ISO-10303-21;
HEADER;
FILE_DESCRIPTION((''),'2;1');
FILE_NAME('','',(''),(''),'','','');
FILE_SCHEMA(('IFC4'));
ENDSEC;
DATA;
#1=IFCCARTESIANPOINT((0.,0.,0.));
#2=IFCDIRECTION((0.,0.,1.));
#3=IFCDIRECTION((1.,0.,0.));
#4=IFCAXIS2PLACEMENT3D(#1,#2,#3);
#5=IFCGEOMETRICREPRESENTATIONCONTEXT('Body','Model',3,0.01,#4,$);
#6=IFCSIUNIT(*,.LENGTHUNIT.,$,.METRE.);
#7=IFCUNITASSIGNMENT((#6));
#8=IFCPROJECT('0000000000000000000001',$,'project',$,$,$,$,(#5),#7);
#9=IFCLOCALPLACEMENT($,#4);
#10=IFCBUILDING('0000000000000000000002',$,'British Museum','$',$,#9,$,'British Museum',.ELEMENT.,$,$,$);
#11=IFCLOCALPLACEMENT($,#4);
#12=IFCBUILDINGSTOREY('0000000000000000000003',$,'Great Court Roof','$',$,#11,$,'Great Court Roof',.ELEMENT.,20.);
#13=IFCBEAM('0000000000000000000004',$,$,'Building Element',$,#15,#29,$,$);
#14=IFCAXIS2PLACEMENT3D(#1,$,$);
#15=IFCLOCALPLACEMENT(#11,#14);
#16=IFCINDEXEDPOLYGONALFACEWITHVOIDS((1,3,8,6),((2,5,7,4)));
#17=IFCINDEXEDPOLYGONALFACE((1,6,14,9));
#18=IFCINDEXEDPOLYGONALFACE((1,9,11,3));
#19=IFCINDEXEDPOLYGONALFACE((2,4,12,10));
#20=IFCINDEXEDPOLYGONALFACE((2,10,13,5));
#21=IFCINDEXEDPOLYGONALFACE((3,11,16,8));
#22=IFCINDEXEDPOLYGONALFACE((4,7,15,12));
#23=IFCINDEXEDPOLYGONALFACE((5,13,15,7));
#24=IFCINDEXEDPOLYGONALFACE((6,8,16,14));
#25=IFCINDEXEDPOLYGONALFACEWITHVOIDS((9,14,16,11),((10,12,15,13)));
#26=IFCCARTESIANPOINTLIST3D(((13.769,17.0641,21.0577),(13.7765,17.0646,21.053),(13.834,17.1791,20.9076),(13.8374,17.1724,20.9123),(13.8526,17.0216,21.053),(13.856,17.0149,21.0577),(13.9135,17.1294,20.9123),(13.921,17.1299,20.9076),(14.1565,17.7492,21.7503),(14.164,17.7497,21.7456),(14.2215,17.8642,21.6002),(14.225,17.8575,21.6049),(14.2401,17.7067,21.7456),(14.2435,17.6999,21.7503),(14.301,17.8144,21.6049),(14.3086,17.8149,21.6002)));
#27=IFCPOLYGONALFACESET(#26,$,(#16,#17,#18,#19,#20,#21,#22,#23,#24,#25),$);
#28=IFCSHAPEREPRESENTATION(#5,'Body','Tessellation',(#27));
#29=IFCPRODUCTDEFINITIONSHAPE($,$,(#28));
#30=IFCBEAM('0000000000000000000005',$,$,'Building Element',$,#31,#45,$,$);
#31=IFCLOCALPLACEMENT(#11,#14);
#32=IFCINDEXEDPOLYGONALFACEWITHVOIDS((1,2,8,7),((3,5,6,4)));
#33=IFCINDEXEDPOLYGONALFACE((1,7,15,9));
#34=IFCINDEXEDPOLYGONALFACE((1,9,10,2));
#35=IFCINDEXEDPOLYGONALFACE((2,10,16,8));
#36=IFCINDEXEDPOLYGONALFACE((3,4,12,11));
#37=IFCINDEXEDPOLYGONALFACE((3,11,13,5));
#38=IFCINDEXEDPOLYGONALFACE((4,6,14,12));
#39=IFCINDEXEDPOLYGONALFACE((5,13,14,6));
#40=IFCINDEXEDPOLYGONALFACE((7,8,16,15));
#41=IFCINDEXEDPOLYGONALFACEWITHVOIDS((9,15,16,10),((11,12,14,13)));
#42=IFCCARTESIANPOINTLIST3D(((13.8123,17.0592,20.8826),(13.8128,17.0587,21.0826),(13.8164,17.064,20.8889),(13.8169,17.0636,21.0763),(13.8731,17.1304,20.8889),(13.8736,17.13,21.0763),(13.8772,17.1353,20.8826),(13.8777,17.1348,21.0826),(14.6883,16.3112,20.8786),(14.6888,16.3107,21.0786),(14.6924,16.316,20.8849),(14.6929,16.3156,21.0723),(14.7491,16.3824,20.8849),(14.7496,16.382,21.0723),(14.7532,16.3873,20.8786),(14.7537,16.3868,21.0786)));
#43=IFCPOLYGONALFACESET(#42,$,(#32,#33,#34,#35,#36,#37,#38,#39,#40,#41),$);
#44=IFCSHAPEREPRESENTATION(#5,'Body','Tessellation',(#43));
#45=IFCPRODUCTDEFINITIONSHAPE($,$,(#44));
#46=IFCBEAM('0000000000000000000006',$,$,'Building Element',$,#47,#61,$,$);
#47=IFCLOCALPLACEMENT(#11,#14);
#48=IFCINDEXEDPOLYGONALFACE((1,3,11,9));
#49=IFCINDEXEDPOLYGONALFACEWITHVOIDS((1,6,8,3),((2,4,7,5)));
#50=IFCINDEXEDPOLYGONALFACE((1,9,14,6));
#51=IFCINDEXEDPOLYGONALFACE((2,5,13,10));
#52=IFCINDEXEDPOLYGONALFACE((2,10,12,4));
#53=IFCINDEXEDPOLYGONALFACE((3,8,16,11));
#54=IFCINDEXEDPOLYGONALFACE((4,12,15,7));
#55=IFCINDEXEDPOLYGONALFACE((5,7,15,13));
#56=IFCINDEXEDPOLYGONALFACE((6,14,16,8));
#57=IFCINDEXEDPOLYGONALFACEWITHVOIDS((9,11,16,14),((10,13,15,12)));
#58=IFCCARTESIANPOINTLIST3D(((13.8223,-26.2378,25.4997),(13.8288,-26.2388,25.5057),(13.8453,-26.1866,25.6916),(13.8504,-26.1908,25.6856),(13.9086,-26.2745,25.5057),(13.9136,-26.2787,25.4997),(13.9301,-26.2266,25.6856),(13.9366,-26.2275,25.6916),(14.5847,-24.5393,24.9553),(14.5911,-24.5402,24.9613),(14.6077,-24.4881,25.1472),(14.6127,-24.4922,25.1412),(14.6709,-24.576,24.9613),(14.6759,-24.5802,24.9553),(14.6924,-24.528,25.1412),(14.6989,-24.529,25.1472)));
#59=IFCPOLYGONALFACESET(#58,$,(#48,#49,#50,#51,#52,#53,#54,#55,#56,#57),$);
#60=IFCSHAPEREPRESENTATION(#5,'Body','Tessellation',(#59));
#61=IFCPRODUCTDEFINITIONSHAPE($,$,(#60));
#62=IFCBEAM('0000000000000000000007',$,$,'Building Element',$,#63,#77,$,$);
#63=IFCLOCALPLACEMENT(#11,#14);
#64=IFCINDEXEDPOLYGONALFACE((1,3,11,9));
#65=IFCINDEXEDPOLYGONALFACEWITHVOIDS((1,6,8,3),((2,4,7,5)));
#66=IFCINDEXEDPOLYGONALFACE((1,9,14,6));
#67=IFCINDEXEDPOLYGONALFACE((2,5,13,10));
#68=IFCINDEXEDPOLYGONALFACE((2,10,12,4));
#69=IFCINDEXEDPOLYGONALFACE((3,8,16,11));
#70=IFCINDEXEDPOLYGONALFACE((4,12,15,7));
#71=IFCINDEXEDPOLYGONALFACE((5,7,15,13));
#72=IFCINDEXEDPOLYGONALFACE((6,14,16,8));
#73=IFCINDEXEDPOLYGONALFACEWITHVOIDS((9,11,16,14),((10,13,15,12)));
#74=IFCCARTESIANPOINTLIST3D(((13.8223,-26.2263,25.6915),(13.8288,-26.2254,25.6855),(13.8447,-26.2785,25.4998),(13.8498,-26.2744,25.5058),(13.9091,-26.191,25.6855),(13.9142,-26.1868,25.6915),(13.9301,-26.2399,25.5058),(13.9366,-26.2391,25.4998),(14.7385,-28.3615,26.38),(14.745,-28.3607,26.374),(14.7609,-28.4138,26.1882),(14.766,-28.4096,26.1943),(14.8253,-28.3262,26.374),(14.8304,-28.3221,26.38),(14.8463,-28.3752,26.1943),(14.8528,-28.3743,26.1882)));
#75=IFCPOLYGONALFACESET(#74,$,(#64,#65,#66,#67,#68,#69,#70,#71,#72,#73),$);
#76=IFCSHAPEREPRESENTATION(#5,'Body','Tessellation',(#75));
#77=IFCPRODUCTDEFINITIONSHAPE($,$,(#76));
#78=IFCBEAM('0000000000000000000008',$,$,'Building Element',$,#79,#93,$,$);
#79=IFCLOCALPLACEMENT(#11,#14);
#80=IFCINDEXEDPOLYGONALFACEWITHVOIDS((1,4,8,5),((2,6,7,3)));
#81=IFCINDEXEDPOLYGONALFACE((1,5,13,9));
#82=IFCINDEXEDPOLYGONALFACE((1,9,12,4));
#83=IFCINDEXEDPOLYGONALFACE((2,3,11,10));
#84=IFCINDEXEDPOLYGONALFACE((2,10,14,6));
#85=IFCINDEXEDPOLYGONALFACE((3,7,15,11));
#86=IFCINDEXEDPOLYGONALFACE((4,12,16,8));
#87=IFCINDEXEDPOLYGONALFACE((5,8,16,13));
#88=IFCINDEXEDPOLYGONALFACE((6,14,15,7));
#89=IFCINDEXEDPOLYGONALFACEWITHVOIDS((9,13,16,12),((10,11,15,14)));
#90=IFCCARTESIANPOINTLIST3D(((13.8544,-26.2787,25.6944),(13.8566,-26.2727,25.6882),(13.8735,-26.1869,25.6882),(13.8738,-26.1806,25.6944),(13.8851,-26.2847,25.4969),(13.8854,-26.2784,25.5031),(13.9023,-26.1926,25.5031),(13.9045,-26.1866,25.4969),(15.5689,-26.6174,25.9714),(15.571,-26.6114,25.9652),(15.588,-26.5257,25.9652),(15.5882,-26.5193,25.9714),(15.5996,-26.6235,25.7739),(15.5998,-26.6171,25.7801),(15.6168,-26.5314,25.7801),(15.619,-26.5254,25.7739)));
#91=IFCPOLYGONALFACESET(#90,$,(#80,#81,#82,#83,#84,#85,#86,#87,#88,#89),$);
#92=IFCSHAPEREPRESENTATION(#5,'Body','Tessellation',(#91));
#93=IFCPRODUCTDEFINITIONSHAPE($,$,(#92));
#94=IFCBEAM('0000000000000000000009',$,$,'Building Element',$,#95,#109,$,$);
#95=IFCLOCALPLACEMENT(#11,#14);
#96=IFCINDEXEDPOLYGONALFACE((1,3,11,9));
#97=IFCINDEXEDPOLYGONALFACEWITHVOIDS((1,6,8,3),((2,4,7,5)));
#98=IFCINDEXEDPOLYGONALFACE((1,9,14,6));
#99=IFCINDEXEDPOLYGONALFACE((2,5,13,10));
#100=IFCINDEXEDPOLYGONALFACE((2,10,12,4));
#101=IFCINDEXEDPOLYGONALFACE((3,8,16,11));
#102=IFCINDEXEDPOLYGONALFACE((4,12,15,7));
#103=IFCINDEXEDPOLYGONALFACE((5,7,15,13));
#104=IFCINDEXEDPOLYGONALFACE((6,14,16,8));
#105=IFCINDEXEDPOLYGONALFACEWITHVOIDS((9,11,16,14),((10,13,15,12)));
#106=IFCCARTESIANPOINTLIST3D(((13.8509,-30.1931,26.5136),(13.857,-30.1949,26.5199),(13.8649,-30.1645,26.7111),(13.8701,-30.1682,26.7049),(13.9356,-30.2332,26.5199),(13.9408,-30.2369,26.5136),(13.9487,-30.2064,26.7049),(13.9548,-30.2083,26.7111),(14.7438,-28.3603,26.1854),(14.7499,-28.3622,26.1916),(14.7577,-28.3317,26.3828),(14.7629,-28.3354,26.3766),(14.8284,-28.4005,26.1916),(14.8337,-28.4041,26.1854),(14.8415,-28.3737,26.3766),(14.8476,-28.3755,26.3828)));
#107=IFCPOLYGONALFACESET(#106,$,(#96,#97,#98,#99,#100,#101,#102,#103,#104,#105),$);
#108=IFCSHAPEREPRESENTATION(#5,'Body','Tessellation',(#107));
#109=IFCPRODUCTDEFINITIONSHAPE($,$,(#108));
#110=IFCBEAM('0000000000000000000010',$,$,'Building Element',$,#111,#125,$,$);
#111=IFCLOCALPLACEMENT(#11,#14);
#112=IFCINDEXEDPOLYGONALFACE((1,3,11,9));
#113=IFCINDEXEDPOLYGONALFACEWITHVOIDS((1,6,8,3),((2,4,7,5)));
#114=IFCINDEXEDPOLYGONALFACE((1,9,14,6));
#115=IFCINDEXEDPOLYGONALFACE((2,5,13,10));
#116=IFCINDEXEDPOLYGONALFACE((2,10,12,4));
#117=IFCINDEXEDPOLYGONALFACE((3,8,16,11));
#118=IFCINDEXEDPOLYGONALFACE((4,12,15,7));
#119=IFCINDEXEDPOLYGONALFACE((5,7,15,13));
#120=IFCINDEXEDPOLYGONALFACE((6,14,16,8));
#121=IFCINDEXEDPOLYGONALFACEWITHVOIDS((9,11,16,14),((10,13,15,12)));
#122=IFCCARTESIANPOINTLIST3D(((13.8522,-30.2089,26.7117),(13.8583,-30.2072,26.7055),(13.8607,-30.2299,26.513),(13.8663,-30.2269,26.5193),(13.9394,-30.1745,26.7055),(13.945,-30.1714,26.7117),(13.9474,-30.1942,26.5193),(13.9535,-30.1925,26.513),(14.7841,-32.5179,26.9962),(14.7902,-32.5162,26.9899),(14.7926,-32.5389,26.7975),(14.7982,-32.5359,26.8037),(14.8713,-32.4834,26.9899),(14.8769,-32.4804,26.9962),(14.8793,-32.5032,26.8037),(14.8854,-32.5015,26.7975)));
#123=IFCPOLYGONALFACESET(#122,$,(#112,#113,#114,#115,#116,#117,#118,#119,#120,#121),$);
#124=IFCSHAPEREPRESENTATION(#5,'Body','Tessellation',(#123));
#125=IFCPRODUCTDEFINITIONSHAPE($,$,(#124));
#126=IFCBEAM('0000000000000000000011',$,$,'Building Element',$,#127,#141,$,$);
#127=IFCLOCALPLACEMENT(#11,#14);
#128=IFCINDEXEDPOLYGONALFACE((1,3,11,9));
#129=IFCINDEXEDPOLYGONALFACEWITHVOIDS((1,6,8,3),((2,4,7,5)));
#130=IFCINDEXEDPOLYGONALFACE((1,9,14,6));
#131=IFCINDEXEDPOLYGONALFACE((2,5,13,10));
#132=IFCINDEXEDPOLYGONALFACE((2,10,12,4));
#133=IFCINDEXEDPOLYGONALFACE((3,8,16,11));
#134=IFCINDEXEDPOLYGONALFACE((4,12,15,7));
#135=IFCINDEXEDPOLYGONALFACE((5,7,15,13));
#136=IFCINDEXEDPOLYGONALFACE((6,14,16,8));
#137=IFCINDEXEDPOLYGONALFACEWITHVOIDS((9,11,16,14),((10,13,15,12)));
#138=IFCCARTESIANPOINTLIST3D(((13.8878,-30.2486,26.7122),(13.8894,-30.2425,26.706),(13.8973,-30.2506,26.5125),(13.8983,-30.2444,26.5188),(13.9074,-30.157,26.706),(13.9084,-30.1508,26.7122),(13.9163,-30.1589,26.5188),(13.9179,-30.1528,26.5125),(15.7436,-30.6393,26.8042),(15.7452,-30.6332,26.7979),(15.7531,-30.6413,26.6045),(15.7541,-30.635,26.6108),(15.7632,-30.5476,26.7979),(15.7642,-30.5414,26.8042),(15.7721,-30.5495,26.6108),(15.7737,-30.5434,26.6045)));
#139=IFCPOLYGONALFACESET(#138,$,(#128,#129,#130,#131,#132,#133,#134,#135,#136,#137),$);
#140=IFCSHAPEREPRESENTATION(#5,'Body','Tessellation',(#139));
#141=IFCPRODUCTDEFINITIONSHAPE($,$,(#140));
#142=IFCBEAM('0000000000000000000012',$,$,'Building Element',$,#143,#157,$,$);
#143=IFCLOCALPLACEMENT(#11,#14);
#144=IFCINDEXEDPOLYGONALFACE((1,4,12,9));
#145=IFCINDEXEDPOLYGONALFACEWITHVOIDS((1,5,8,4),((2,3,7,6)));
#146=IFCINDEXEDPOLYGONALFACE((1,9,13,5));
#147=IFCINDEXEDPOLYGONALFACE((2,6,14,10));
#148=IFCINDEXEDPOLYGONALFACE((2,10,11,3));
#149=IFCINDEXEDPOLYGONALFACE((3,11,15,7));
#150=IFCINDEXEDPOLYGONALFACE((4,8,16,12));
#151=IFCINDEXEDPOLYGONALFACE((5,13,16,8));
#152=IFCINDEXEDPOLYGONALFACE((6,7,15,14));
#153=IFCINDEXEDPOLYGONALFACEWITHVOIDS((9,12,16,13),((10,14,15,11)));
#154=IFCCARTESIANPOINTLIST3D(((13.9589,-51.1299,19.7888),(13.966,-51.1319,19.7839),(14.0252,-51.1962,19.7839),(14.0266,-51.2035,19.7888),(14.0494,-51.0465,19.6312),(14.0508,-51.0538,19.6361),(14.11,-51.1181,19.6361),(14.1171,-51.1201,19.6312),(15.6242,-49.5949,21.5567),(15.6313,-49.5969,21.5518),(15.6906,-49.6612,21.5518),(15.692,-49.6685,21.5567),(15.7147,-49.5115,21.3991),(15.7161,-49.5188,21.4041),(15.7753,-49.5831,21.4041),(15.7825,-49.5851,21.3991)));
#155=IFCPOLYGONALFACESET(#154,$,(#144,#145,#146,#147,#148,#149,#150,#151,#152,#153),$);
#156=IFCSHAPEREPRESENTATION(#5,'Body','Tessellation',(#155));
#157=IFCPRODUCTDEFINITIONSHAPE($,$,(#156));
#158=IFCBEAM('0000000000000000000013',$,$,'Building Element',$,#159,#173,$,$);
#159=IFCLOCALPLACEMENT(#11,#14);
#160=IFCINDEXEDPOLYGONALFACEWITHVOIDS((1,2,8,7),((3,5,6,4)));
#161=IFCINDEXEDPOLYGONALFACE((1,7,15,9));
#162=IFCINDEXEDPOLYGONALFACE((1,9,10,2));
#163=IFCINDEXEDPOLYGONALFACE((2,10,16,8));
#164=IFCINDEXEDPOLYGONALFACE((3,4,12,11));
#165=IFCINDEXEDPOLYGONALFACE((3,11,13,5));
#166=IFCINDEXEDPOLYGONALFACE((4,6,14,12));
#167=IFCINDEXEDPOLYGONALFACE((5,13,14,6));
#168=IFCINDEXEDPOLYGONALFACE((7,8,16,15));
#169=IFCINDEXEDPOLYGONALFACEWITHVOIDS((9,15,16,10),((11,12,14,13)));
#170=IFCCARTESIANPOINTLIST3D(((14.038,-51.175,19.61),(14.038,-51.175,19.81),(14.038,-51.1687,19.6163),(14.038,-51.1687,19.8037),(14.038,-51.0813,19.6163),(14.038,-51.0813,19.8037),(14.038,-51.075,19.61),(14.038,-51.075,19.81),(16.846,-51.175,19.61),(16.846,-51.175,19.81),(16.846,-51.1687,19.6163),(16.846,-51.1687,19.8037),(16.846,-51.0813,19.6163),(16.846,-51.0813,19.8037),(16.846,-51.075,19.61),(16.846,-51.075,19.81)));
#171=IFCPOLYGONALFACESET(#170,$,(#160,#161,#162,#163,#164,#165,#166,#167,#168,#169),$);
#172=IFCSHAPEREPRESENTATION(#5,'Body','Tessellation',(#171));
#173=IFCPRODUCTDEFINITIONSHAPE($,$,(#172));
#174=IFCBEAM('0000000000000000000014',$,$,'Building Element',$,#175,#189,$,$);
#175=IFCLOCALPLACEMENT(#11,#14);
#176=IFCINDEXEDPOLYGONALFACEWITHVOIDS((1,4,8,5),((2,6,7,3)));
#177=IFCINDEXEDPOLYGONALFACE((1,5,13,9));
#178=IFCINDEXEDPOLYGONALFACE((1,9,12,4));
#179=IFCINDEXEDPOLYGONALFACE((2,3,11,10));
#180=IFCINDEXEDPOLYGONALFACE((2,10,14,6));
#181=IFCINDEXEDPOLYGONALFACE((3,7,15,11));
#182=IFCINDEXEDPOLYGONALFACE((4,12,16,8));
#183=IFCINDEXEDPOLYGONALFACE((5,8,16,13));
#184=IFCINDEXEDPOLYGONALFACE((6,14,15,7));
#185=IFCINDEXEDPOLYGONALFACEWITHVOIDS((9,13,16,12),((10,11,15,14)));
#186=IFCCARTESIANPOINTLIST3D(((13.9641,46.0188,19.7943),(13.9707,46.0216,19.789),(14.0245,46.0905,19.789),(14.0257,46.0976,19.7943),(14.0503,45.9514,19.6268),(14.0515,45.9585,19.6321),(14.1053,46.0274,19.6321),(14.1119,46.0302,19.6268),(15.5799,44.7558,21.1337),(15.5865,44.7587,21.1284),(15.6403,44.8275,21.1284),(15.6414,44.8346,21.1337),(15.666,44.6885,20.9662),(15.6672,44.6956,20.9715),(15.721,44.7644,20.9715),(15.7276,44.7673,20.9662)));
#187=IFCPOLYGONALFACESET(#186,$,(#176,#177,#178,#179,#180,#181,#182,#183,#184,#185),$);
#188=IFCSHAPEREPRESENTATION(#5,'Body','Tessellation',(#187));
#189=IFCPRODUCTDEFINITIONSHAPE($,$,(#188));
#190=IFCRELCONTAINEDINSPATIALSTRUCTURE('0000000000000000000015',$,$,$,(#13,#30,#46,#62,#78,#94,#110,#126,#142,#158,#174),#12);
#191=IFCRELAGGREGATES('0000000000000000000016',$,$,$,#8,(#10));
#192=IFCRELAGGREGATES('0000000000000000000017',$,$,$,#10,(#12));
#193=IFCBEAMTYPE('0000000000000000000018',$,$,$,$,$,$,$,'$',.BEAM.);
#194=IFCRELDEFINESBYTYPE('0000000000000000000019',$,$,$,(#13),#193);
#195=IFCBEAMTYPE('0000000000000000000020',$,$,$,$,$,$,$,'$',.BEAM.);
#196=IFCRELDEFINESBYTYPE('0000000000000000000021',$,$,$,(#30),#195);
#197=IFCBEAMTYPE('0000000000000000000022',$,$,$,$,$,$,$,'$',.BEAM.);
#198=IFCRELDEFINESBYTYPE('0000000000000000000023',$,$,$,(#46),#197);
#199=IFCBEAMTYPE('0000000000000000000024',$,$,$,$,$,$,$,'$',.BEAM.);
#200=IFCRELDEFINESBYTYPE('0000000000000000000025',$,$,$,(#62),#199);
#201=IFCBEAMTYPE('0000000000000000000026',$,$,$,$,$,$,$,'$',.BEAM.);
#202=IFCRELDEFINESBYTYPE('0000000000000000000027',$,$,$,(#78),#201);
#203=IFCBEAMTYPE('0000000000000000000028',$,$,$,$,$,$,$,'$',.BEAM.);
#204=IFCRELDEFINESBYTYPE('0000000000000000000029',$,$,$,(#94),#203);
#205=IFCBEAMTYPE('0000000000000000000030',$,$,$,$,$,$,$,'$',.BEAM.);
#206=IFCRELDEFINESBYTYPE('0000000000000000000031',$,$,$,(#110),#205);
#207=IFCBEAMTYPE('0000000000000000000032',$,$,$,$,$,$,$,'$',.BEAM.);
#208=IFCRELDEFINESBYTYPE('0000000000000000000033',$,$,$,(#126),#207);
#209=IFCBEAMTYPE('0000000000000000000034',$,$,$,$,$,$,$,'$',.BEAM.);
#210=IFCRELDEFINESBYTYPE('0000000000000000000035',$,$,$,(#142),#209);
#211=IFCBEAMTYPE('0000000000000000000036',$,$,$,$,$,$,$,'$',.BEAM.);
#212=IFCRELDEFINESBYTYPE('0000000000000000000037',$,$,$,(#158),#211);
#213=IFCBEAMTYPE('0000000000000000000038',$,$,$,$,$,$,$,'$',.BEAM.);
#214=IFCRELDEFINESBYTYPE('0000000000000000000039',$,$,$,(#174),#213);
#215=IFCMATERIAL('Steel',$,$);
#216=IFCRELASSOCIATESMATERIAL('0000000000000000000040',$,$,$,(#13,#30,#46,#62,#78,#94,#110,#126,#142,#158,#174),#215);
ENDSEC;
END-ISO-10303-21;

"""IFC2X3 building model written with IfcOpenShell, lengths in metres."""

from ifc_helpers import new_model, si_unit, frame, origin_with_axes, origin_2d, place, context, project, spatial, hollow_rectangle, extrude, material, type_object, element, save


model = new_model("IFC2X3")

# Units and contexts
model_context = context("Model", 3, precision=0.01, world=origin_with_axes(), identifier="Body")
ifc_project = project(units=[si_unit("LENGTHUNIT", "METRE")], contexts=[model_context])

# Building, storey
building_placement = place(None, origin_with_axes())
building = spatial("IfcBuilding", under=ifc_project, at=building_placement, Name="British Museum", Description="$", LongName="British Museum", CompositionType="ELEMENT")
storey_placement = place(None, origin_with_axes())
storey = spatial("IfcBuildingStorey", under=building, at=storey_placement, Name="Great Court Roof", Description="$", LongName="Great Court Roof", CompositionType="ELEMENT", Elevation=20.0)

# Beams
ifc_material = material(Name="Steel")
beam_type_1 = type_object("IfcBeamType", ElementType="$", PredefinedType="BEAM")
beam_1_placement = place(None, origin_with_axes())
element("IfcBeam", 1, at=beam_1_placement, inside=storey, type_object=beam_type_1, material=ifc_material, Description="Building Element", context=model_context, shape_type="SweptSolid", body=[
    extrude(hollow_rectangle(XDim=0.1, YDim=0.2, WallThickness=0.0063, InnerFilletRadius=-0.0063, OuterFilletRadius=0.0, at=origin_2d()), frame((13.845, 17.097, 20.9826), z_axis=(0.369627, 0.653425, 0.660614), x_axis=(-0.870392, 0.49236, 0.0)), (0.0, 0.0, 1.0), 1.0484),
])
beam_type_2 = type_object("IfcBeamType", ElementType="$", PredefinedType="BEAM")
beam_2_placement = place(None, origin_with_axes())
element("IfcBeam", 2, at=beam_2_placement, inside=storey, type_object=beam_type_2, material=ifc_material, Description="Building Element", context=model_context, shape_type="SweptSolid", body=[
    extrude(hollow_rectangle(XDim=0.1, YDim=0.2, WallThickness=0.0063, InnerFilletRadius=-0.0063, OuterFilletRadius=0.0, at=origin_2d()), frame((13.845, 17.097, 20.9826), z_axis=(0.760477, -0.649356, -0.003504), x_axis=(0.64936, 0.760481, 0.0)), (0.0, 0.0, 1.0), 1.1519),
])
beam_type_3 = type_object("IfcBeamType", ElementType="$", PredefinedType="BEAM")
beam_3_placement = place(None, origin_with_axes())
element("IfcBeam", 3, at=beam_3_placement, inside=storey, type_object=beam_type_3, material=ifc_material, Description="Building Element", context=model_context, shape_type="SweptSolid", body=[
    extrude(hollow_rectangle(XDim=0.1, YDim=0.2, WallThickness=0.0063, InnerFilletRadius=-0.0063, OuterFilletRadius=0.0, at=origin_2d()), frame((13.8795, -26.2327, 25.5957), z_axis=(0.393009, 0.875656, -0.28066), x_axis=(-0.912325, 0.409466, 0.0)), (0.0, 0.0, 1.0), 1.9397),
])
beam_type_4 = type_object("IfcBeamType", ElementType="$", PredefinedType="BEAM")
beam_4_placement = place(None, origin_with_axes())
element("IfcBeam", 4, at=beam_4_placement, inside=storey, type_object=beam_type_4, material=ifc_material, Description="Building Element", context=model_context, shape_type="SweptSolid", body=[
    extrude(hollow_rectangle(XDim=0.1, YDim=0.2, WallThickness=0.0063, InnerFilletRadius=-0.0063, OuterFilletRadius=0.0, at=origin_2d()), frame((13.8795, -26.2327, 25.5957), z_axis=(0.378075, -0.88111, 0.284086), x_axis=(0.918973, 0.394321, 0.0)), (0.0, 0.0, 1.0), 2.4234),
])
beam_type_5 = type_object("IfcBeamType", ElementType="$", PredefinedType="BEAM")
beam_5_placement = place(None, origin_with_axes())
element("IfcBeam", 5, at=beam_5_placement, inside=storey, type_object=beam_type_5, material=ifc_material, Description="Building Element", context=model_context, shape_type="SweptSolid", body=[
    extrude(hollow_rectangle(XDim=0.1, YDim=0.2, WallThickness=0.0063, InnerFilletRadius=-0.0063, OuterFilletRadius=0.0, at=origin_2d()), frame((13.8795, -26.2327, 25.5957), z_axis=(0.968939, -0.191451, 0.156537), x_axis=(0.193841, 0.981033, 0.0)), (0.0, 0.0, 1.0), 1.7694),
])
beam_type_6 = type_object("IfcBeamType", ElementType="$", PredefinedType="BEAM")
beam_6_placement = place(None, origin_with_axes())
element("IfcBeam", 6, at=beam_6_placement, inside=storey, type_object=beam_type_6, material=ifc_material, Description="Building Element", context=model_context, shape_type="SweptSolid", body=[
    extrude(hollow_rectangle(XDim=0.1, YDim=0.2, WallThickness=0.0063, InnerFilletRadius=-0.0063, OuterFilletRadius=0.0, at=origin_2d()), frame((13.9028, -30.2007, 26.6124), z_axis=(0.432382, 0.887568, -0.158963), x_axis=(-0.898999, 0.437951, 0.0)), (0.0, 0.0, 1.0), 2.0649),
])
beam_type_7 = type_object("IfcBeamType", ElementType="$", PredefinedType="BEAM")
beam_7_placement = place(None, origin_with_axes())
element("IfcBeam", 7, at=beam_7_placement, inside=storey, type_object=beam_type_7, material=ifc_material, Description="Building Element", context=model_context, shape_type="SweptSolid", body=[
    extrude(hollow_rectangle(XDim=0.1, YDim=0.2, WallThickness=0.0063, InnerFilletRadius=-0.0063, OuterFilletRadius=0.0, at=origin_2d()), frame((13.9028, -30.2007, 26.6124), z_axis=(0.371848, -0.921327, 0.113512), x_axis=(0.927321, 0.374267, 0.0)), (0.0, 0.0, 1.0), 2.5061),
])
beam_type_8 = type_object("IfcBeamType", ElementType="$", PredefinedType="BEAM")
beam_8_placement = place(None, origin_with_axes())
element("IfcBeam", 8, at=beam_8_placement, inside=storey, type_object=beam_type_8, material=ifc_material, Description="Building Element", context=model_context, shape_type="SweptSolid", body=[
    extrude(hollow_rectangle(XDim=0.1, YDim=0.2, WallThickness=0.0063, InnerFilletRadius=-0.0063, OuterFilletRadius=0.0, at=origin_2d()), frame((13.9028, -30.2007, 26.6124), z_axis=(0.977404, -0.205754, 0.048444), x_axis=(0.205996, 0.978553, 0.0)), (0.0, 0.0, 1.0), 1.8987),
])
beam_type_9 = type_object("IfcBeamType", ElementType="$", PredefinedType="BEAM")
beam_9_placement = place(None, origin_with_axes())
element("IfcBeam", 9, at=beam_9_placement, inside=storey, type_object=beam_type_9, material=ifc_material, Description="Building Element", context=model_context, shape_type="SweptSolid", body=[
    extrude(hollow_rectangle(XDim=0.1, YDim=0.2, WallThickness=0.0063, InnerFilletRadius=-0.0063, OuterFilletRadius=0.0, at=origin_2d()), frame((14.038, -51.125, 19.71), z_axis=(0.579617, 0.534253, 0.615319), x_axis=(-0.677747, 0.735296, 0.0)), (0.0, 0.0, 1.0), 2.8732),
])
beam_type_10 = type_object("IfcBeamType", ElementType="$", PredefinedType="BEAM")
beam_10_placement = place(None, origin_with_axes())
element("IfcBeam", 10, at=beam_10_placement, inside=storey, type_object=beam_type_10, material=ifc_material, Description="Building Element", context=model_context, shape_type="SweptSolid", body=[
    extrude(hollow_rectangle(XDim=0.1, YDim=0.2, WallThickness=0.0063, InnerFilletRadius=-0.0063, OuterFilletRadius=0.0, at=origin_2d()), frame((14.038, -51.125, 19.71), z_axis=(1.0, 0.0, 0.0), x_axis=(0.0, 1.0, 0.0)), (0.0, 0.0, 1.0), 2.808),
])
beam_type_11 = type_object("IfcBeamType", ElementType="$", PredefinedType="BEAM")
beam_11_placement = place(None, origin_with_axes())
element("IfcBeam", 11, at=beam_11_placement, inside=storey, type_object=beam_type_11, material=ifc_material, Description="Building Element", context=model_context, shape_type="SweptSolid", body=[
    extrude(hollow_rectangle(XDim=0.1, YDim=0.2, WallThickness=0.0063, InnerFilletRadius=-0.0063, OuterFilletRadius=0.0, at=origin_2d()), frame((14.038, 46.0245, 19.7106), z_axis=(0.659638, -0.515615, 0.546826), x_axis=(0.615846, 0.787866, 0.0)), (0.0, 0.0, 1.0), 2.4494),
])

save(model, "model.ifc")
